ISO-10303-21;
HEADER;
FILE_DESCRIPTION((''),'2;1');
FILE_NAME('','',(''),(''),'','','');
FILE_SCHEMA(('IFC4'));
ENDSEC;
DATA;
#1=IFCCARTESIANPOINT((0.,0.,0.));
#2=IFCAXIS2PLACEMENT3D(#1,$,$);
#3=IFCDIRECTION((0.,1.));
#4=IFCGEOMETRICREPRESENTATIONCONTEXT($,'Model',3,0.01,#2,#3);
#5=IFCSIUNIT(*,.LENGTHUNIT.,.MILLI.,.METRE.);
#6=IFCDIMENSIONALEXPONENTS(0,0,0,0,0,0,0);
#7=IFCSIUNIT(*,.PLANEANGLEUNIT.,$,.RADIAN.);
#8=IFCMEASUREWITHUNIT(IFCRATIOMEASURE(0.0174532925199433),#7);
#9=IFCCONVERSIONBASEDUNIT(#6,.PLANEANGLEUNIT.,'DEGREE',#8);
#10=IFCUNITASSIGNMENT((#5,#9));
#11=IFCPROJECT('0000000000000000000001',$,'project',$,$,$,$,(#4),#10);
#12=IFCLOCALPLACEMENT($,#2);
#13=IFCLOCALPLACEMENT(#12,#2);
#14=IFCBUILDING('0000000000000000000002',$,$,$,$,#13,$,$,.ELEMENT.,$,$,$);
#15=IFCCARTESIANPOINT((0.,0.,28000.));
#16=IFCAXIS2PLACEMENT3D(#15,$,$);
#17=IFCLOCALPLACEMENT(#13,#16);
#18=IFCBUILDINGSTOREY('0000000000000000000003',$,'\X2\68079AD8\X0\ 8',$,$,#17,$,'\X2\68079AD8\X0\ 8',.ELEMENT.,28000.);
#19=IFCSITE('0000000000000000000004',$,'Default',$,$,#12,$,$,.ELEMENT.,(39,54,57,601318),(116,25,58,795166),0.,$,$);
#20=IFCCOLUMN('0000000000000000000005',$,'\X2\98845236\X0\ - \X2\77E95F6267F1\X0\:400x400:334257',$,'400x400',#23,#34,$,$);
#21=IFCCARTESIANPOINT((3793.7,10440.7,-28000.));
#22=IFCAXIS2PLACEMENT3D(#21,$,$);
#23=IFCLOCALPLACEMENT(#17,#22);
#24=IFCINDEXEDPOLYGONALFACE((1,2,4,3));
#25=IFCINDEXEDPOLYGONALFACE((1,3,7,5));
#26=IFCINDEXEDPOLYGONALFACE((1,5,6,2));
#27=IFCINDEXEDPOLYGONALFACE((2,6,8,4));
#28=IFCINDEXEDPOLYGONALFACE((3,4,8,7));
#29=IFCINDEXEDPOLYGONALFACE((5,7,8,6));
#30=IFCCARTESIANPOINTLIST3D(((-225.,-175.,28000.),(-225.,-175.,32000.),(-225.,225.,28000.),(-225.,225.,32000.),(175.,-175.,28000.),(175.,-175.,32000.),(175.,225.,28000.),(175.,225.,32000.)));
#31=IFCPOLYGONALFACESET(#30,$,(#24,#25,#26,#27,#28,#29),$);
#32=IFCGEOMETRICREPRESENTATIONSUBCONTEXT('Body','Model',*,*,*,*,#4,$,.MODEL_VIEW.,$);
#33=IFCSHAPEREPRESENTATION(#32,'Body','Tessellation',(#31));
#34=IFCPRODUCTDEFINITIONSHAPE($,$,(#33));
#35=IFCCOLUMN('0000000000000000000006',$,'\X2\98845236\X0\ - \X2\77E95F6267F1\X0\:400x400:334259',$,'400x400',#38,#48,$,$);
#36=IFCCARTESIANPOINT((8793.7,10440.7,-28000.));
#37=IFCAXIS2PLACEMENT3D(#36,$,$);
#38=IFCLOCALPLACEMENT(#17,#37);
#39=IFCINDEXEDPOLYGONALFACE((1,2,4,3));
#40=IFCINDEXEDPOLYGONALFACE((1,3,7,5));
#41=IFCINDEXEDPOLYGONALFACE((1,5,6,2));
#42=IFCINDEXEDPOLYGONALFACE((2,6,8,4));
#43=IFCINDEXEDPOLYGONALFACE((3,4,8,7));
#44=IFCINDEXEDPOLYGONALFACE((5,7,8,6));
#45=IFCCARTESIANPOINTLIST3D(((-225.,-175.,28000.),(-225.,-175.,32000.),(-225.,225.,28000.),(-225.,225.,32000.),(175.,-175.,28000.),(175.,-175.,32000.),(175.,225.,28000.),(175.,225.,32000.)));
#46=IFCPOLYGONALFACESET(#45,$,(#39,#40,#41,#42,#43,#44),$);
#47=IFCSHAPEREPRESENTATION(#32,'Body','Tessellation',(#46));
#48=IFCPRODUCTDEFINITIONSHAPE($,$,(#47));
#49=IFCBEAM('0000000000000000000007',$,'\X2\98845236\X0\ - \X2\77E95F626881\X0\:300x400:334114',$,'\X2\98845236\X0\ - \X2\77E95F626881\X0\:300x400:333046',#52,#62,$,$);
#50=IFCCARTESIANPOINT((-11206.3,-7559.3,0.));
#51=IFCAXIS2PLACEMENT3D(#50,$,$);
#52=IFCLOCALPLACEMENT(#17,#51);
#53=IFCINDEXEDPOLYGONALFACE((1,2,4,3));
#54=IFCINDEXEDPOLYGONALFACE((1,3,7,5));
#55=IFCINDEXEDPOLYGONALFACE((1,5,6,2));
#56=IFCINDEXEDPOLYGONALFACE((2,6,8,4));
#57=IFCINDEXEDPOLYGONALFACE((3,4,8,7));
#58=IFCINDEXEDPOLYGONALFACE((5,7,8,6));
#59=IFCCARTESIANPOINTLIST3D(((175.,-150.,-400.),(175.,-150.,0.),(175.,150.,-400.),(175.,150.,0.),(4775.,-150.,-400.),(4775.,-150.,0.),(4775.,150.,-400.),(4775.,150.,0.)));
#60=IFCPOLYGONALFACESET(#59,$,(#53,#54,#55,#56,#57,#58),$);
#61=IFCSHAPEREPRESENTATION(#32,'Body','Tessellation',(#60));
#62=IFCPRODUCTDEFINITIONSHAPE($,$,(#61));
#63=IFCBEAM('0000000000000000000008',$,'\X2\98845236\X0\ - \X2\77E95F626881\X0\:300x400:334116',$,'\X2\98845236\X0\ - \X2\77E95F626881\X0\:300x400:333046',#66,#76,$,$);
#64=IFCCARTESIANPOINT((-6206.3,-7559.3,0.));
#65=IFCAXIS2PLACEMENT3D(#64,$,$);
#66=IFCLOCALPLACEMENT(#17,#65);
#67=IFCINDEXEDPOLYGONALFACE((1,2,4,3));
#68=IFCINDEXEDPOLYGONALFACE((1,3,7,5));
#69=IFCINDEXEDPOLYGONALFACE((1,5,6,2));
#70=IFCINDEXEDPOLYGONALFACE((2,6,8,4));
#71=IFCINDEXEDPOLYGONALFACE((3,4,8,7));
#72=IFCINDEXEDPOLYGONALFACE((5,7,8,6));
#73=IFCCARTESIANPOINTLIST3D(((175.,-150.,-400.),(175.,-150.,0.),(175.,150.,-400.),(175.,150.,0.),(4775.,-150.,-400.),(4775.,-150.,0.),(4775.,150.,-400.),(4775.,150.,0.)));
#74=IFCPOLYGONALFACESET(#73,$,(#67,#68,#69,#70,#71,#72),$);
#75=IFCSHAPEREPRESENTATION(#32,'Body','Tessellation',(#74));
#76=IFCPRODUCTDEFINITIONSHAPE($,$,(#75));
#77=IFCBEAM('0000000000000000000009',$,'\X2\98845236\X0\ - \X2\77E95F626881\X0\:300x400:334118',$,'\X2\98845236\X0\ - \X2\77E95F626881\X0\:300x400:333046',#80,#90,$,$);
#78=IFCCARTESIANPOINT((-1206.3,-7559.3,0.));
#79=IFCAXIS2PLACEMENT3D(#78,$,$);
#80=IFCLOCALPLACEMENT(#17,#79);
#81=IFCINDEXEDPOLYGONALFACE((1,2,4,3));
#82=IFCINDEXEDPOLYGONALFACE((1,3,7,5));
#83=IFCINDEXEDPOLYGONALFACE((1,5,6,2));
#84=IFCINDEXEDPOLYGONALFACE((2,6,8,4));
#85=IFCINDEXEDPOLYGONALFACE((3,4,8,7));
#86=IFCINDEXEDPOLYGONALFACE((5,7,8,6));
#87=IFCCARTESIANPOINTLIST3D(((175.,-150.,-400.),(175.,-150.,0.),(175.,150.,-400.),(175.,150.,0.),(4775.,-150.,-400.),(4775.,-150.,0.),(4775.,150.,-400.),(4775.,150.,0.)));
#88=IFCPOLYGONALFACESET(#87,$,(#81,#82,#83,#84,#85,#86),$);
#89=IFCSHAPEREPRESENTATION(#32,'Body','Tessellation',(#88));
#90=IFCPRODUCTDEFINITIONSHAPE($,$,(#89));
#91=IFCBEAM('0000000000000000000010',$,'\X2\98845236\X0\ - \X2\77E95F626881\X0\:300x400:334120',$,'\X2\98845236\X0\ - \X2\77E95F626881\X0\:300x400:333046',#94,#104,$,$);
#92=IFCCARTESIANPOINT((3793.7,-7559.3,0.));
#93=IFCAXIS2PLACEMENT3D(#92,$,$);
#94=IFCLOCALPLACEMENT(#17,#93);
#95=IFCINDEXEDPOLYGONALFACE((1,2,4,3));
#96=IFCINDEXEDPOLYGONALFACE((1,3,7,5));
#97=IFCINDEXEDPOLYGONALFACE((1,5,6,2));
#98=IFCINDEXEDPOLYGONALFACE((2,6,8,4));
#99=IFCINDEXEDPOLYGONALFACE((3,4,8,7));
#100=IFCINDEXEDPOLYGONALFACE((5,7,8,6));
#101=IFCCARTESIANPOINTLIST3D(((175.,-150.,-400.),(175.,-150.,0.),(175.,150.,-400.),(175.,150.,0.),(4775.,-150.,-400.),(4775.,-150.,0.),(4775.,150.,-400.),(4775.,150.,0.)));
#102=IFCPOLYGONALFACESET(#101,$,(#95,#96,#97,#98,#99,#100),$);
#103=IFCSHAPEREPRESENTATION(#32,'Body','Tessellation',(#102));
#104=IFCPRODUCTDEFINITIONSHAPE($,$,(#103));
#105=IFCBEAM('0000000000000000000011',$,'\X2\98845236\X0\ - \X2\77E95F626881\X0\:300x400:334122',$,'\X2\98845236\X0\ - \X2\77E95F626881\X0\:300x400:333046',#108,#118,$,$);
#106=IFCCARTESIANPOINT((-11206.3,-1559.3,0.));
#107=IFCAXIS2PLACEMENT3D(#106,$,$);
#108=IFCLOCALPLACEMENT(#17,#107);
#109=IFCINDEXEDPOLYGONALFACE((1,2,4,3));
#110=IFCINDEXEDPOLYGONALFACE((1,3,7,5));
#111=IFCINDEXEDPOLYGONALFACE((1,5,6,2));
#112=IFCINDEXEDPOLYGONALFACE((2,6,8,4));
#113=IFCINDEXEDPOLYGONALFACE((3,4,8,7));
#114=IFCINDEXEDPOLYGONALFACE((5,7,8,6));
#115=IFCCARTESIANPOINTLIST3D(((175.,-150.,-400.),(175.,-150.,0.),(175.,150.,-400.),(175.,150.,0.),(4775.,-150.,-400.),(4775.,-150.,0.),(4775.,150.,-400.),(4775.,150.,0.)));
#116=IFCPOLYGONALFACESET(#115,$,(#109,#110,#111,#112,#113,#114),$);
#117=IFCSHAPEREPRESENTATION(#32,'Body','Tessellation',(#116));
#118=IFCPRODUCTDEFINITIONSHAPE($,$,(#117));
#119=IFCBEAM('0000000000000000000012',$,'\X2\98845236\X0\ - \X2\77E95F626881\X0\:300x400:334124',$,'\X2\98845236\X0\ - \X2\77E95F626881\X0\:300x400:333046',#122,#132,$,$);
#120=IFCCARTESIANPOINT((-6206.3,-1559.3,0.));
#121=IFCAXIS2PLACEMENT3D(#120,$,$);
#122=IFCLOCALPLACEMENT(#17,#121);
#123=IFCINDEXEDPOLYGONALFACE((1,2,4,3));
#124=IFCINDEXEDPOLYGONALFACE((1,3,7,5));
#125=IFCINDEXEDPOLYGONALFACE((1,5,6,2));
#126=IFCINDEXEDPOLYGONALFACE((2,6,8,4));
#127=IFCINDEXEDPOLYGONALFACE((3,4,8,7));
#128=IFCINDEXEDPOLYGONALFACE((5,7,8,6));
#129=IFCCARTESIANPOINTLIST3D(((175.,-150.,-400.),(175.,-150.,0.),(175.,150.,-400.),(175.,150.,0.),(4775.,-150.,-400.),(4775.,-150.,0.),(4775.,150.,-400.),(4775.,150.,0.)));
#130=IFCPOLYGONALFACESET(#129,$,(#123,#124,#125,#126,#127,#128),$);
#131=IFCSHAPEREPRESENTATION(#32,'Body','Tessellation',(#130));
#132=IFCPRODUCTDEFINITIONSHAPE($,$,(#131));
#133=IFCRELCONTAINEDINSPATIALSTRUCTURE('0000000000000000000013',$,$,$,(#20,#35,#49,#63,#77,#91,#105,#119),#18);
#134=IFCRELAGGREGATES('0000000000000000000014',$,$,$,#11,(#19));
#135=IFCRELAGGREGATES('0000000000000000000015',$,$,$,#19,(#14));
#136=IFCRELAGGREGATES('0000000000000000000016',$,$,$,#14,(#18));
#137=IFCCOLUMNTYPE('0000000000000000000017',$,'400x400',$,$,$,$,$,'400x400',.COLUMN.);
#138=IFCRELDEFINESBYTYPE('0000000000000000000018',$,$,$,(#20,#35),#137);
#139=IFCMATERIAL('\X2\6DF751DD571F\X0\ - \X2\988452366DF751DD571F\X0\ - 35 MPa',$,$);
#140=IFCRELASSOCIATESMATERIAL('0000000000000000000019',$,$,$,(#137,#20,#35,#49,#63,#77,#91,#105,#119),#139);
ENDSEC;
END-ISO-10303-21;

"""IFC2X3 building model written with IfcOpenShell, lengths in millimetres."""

from ifc_helpers import new_model, entity, si_unit, converted_unit, direction, frame, frame_2d, origin, place, context, subcontext, project, spatial, rectangle, extrude, source, transform, mapped, material, type_object, type_shapes, element, save


model = new_model("IFC2X3")

# Units and contexts
model_context = context("Model", 3, precision=0.01, world=origin(), true_north=direction((0.0, 1.0)))
body_context = subcontext(model_context, "Body", "Model", "MODEL_VIEW")
ifc_project = project(units=[si_unit("LENGTHUNIT", "METRE", prefix="MILLI"), converted_unit("PLANEANGLEUNIT", "DEGREE", entity("IfcRatioMeasure", 0.0174532925199433), si_unit("PLANEANGLEUNIT", "RADIAN"), dimensions=[0, 0, 0, 0, 0, 0, 0])], contexts=[model_context])

# Site, building, storey
site_placement = place(None, origin())
site = spatial("IfcSite", under=ifc_project, at=site_placement, Name="Default", CompositionType="ELEMENT", RefLatitude=(39, 54, 57, 601318), RefLongitude=(116, 25, 58, 795166), RefElevation=0.0)
building_placement = place(site_placement, origin())
building = spatial("IfcBuilding", under=site, at=building_placement, CompositionType="ELEMENT")
storey_placement = place(building_placement, frame((0.0, 0.0, 28000.0)))
storey = spatial("IfcBuildingStorey", under=building, at=storey_placement, Name="标高 8", LongName="标高 8", CompositionType="ELEMENT", Elevation=28000.0)

# Columns
ifc_material = material(Name="混凝土 - 预制混凝土 - 35 MPa")
column_type = type_object("IfcColumnType", Name="400x400", ElementType="400x400", PredefinedType="COLUMN", material=ifc_material)
shared_shape = source(origin(), body_context, "Body", "SweptSolid", [
    extrude(rectangle(XDim=400.0, YDim=400.0, at=frame_2d((0.0, 0.0), x_axis=(1.0, 0.0))), frame((-25.0, 25.0, 28000.0)), (0.0, 0.0, 1.0), 4000.0),
])
type_shapes(column_type, [shared_shape])
for number, where, name in (
    (1, (3793.7, 10440.7, -28000.0), "预制 - 矩形柱:400x400:334257"),
    (2, (8793.7, 10440.7, -28000.0), "预制 - 矩形柱:400x400:334259"),
):
    element("IfcColumn", number, at=place(storey_placement, frame(where)), inside=storey, type_object=column_type, material=ifc_material, Name=name, ObjectType="400x400", context=body_context, shape_type="MappedRepresentation", body=[
        mapped(shared_shape, transform((0.0, 0.0, 0.0), scale=1.0)),
    ])

# Beams
for number, where, name in (
    (3, (-11206.3, -7559.3, 0.0), "预制 - 矩形梁:300x400:334114"),
    (4, (-6206.3, -7559.3, 0.0), "预制 - 矩形梁:300x400:334116"),
):
    element("IfcBeam", number, at=place(storey_placement, frame(where)), inside=storey, material=ifc_material, Name=name, ObjectType="预制 - 矩形梁:300x400:333046", context=body_context, shape_type="SweptSolid", body=[
        extrude(rectangle(XDim=400.0, YDim=300.0, at=frame_2d((0.0, 0.0), x_axis=(1.0, 0.0))), frame((175.0, 0.0, -200.0), z_axis=(1.0, 0.0, 0.0), x_axis=(0.0, 0.0, -1.0)), (0.0, 0.0, 1.0), 4600.0),
    ])
for number, where, name in (
    (5, (-1206.3, -7559.3, 0.0), "预制 - 矩形梁:300x400:334118"),
    (6, (3793.7, -7559.3, 0.0), "预制 - 矩形梁:300x400:334120"),
):
    element("IfcBeam", number, at=place(storey_placement, frame(where)), inside=storey, material=ifc_material, Name=name, ObjectType="预制 - 矩形梁:300x400:333046", context=body_context, shape_type="SweptSolid", body=[
        extrude(rectangle(XDim=400.0, YDim=300.0, at=frame_2d((0.0, 0.0), x_axis=(1.0, 0.0))), frame((175.0, 0.0, -200.0), z_axis=(1.0, 0.0, 0.0), x_axis=(0.0, 0.0, -1.0)), (0.0, 0.0, 1.0), 4600.0),
    ])
for number, where, name in (
    (7, (-11206.3, -1559.3, 0.0), "预制 - 矩形梁:300x400:334122"),
    (8, (-6206.3, -1559.3, 0.0), "预制 - 矩形梁:300x400:334124"),
):
    element("IfcBeam", number, at=place(storey_placement, frame(where)), inside=storey, material=ifc_material, Name=name, ObjectType="预制 - 矩形梁:300x400:333046", context=body_context, shape_type="SweptSolid", body=[
        extrude(rectangle(XDim=400.0, YDim=300.0, at=frame_2d((0.0, 0.0), x_axis=(1.0, 0.0))), frame((175.0, 0.0, -200.0), z_axis=(1.0, 0.0, 0.0), x_axis=(0.0, 0.0, -1.0)), (0.0, 0.0, 1.0), 4600.0),
    ])

save(model, "model.ifc")
